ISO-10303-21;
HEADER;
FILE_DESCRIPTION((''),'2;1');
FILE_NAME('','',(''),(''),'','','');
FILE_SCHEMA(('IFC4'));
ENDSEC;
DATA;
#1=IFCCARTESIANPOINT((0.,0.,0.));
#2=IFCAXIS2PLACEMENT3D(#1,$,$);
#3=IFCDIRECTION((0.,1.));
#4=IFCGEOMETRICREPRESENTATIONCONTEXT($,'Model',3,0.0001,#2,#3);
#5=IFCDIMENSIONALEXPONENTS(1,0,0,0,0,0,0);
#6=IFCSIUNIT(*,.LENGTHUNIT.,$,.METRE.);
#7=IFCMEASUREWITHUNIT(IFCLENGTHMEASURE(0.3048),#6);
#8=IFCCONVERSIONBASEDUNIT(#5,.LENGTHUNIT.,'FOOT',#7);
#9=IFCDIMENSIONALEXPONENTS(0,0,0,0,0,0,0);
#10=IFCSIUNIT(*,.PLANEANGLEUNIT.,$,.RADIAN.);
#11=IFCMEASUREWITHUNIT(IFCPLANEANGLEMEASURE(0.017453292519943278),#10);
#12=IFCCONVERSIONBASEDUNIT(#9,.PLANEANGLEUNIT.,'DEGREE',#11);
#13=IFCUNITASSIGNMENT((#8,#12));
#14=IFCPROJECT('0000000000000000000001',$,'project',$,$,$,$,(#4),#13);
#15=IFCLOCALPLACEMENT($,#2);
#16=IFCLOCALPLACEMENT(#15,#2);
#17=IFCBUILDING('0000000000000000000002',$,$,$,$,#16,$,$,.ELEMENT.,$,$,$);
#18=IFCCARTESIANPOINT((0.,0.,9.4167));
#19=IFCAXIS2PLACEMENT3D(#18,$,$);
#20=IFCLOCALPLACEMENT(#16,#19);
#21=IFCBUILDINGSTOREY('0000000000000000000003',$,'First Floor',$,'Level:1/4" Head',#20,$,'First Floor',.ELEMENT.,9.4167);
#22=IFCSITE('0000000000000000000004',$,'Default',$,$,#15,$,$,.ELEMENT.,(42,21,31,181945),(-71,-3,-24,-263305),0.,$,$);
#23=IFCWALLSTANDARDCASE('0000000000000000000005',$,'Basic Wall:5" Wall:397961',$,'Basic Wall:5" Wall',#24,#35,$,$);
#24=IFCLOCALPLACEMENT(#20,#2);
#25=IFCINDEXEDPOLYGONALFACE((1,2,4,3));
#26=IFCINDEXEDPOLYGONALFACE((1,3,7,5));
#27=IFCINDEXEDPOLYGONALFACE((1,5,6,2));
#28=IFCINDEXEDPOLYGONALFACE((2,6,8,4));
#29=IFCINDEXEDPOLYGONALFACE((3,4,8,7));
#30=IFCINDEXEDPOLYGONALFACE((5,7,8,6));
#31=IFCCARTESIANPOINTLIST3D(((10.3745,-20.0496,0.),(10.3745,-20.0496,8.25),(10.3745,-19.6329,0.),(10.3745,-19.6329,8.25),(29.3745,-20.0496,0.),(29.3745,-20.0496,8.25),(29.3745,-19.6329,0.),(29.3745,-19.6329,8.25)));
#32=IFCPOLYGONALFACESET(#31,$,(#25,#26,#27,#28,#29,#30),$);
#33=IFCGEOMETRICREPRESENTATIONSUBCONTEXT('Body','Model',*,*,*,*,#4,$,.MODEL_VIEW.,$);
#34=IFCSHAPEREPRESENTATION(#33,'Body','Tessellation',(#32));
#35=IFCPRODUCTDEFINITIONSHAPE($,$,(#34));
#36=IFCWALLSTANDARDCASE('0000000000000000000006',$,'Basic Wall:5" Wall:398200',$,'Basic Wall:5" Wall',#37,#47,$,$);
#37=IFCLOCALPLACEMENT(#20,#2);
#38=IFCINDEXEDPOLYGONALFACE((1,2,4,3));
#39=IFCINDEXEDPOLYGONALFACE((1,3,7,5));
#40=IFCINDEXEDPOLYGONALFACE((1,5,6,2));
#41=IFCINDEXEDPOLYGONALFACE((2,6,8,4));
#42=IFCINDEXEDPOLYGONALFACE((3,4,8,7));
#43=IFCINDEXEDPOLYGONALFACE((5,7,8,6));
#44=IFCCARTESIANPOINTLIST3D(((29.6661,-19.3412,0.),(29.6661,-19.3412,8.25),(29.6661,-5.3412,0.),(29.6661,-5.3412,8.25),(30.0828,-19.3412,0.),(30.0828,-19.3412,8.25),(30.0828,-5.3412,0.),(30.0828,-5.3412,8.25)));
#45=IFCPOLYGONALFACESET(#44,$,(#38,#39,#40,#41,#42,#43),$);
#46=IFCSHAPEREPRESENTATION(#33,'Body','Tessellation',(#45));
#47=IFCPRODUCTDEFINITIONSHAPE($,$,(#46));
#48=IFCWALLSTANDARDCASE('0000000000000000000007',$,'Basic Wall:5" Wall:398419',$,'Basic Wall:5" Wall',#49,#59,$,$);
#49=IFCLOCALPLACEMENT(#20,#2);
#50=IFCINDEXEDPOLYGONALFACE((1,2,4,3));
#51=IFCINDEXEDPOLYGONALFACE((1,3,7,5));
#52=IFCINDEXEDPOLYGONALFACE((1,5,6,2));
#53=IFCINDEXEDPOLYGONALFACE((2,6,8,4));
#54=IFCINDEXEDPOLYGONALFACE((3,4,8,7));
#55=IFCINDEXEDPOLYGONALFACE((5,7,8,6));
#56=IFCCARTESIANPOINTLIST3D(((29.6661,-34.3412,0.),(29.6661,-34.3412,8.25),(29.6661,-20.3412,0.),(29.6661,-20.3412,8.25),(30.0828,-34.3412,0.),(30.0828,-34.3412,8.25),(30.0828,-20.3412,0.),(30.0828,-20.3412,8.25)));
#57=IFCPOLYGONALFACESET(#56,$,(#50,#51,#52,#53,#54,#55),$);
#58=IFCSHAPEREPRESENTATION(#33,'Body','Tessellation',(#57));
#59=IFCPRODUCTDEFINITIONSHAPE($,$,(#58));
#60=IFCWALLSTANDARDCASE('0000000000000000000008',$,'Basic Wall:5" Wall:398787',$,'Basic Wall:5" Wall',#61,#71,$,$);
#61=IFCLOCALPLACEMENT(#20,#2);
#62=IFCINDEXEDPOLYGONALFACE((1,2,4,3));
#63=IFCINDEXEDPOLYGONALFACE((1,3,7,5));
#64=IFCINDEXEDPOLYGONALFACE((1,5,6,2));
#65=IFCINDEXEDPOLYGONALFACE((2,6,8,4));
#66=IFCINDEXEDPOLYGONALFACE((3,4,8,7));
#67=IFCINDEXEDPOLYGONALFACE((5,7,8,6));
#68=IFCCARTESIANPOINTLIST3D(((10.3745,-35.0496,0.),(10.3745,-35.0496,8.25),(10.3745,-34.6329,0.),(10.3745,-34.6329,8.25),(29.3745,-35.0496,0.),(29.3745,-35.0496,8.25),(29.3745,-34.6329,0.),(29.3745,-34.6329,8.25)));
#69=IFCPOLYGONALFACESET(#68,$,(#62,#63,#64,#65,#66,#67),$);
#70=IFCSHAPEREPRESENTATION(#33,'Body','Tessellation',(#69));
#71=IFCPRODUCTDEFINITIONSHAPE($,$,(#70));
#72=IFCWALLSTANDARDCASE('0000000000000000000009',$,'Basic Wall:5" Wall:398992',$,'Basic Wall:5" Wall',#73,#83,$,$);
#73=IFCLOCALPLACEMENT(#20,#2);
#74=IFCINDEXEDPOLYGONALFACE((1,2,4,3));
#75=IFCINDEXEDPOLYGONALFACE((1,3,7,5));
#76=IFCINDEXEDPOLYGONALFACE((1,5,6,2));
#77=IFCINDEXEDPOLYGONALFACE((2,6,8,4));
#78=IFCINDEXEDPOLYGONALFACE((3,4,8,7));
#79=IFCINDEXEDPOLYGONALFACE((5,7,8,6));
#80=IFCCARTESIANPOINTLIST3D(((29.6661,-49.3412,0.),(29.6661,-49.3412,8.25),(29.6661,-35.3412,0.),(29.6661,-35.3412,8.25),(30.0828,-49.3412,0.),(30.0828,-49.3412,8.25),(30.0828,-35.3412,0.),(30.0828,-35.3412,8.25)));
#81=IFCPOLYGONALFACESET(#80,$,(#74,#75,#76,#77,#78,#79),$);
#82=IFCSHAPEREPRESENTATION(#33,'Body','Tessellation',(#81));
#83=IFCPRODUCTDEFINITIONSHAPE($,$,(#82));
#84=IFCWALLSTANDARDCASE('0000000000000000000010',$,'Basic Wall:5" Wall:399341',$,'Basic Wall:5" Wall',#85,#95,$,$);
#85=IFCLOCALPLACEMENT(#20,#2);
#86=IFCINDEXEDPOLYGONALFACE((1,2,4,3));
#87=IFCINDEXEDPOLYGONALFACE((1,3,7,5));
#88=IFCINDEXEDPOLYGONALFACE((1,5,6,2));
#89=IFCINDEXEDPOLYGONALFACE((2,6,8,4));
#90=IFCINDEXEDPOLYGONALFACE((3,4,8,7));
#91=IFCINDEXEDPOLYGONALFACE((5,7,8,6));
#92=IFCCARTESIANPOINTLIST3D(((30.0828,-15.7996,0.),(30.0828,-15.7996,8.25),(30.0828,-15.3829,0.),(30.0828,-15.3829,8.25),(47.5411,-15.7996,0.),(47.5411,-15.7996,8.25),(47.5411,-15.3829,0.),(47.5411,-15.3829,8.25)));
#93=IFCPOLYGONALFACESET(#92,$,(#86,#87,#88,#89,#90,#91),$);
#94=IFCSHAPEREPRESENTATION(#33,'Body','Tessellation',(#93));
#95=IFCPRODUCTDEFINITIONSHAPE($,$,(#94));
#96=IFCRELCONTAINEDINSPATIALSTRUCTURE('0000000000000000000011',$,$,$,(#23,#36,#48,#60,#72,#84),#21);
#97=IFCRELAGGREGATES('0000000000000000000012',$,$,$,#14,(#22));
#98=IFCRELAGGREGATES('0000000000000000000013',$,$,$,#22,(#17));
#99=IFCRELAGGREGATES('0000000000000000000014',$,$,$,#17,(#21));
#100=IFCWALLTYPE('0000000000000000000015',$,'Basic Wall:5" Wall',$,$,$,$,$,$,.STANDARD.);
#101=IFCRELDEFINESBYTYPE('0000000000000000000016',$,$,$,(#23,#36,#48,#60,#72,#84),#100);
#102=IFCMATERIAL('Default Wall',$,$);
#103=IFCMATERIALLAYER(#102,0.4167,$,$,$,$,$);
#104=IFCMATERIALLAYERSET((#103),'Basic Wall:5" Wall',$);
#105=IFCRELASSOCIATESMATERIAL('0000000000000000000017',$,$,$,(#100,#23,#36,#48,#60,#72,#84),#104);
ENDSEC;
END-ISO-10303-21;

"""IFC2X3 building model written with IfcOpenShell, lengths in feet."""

from ifc_helpers import new_model, entity, si_unit, converted_unit, direction, frame, frame_2d, origin, place, context, subcontext, project, spatial, rectangle, extrude, material, layer, layer_set, layer_usage, type_object, element, save


model = new_model("IFC2X3")

# Units and contexts
model_context = context("Model", 3, precision=0.0001, world=origin(), true_north=direction((0.0, 1.0)))
body_context = subcontext(model_context, "Body", "Model", "MODEL_VIEW")
ifc_project = project(units=[converted_unit("LENGTHUNIT", "FOOT", entity("IfcLengthMeasure", 0.3048), si_unit("LENGTHUNIT", "METRE"), dimensions=[1, 0, 0, 0, 0, 0, 0]), converted_unit("PLANEANGLEUNIT", "DEGREE", entity("IfcPlaneAngleMeasure", 0.017453292519943278), si_unit("PLANEANGLEUNIT", "RADIAN"), dimensions=[0, 0, 0, 0, 0, 0, 0])], contexts=[model_context])

# Site, building, storey
site_placement = place(None, origin())
site = spatial("IfcSite", under=ifc_project, at=site_placement, Name="Default", CompositionType="ELEMENT", RefLatitude=(42, 21, 31, 181945), RefLongitude=(-71, -3, -24, -263305), RefElevation=0.0)
building_placement = place(site_placement, origin())
building = spatial("IfcBuilding", under=site, at=building_placement, CompositionType="ELEMENT")
storey_placement = place(building_placement, frame((0.0, 0.0, 9.4167)))
storey = spatial("IfcBuildingStorey", under=building, at=storey_placement, Name="First Floor", ObjectType="Level:1/4\" Head", LongName="First Floor", CompositionType="ELEMENT", Elevation=9.4167)

# Walls
ifc_material_1 = material(Name="Default Wall")
ifc_layer_1 = layer(ifc_material_1, 0.4167)
ifc_layer_set_1 = layer_set([ifc_layer_1], Name="Basic Wall:5\" Wall")
ifc_layer_usage_1 = layer_usage(ifc_layer_set_1, "AXIS2", "NEGATIVE", 0.2083)
wall_type_1 = type_object("IfcWallType", Name="Basic Wall:5\" Wall", PredefinedType="STANDARD", material=ifc_layer_set_1)
wall_1_placement = place(storey_placement, frame((10.3745, -19.8412, 0.0)))
element("IfcWallStandardCase", 1, at=wall_1_placement, inside=storey, type_object=wall_type_1, material=ifc_layer_usage_1, Name="Basic Wall:5\" Wall:397961", ObjectType="Basic Wall:5\" Wall", context=body_context, shape_type="SweptSolid", body=[
    extrude(rectangle(XDim=19.0, YDim=0.4167, at=frame_2d((9.5, 0.0), x_axis=(-1.0, 0.0))), origin(), (0.0, 0.0, 1.0), 8.25),
])
wall_2_placement = place(storey_placement, frame((29.8745, -19.3412, 0.0), z_axis=(0.0, 0.0, 1.0), x_axis=(0.0, 1.0, 0.0)))
element("IfcWallStandardCase", 2, at=wall_2_placement, inside=storey, type_object=wall_type_1, material=ifc_layer_usage_1, Name="Basic Wall:5\" Wall:398200", ObjectType="Basic Wall:5\" Wall", context=body_context, shape_type="SweptSolid", body=[
    extrude(rectangle(XDim=14.0, YDim=0.4167, at=frame_2d((7.0, 0.0), x_axis=(-1.0, 0.0))), origin(), (0.0, 0.0, 1.0), 8.25),
])
wall_3_placement = place(storey_placement, frame((29.8745, -20.3412, 0.0), z_axis=(0.0, 0.0, 1.0), x_axis=(0.0, -1.0, 0.0)))
element("IfcWallStandardCase", 3, at=wall_3_placement, inside=storey, type_object=wall_type_1, material=ifc_layer_usage_1, Name="Basic Wall:5\" Wall:398419", ObjectType="Basic Wall:5\" Wall", context=body_context, shape_type="SweptSolid", body=[
    extrude(rectangle(XDim=14.0, YDim=0.4167, at=frame_2d((7.0, 0.0), x_axis=(-1.0, 0.0))), origin(), (0.0, 0.0, 1.0), 8.25),
])
wall_4_placement = place(storey_placement, frame((29.3745, -34.8412, 0.0), z_axis=(0.0, 0.0, 1.0), x_axis=(-1.0, 0.0, 0.0)))
element("IfcWallStandardCase", 4, at=wall_4_placement, inside=storey, type_object=wall_type_1, material=ifc_layer_usage_1, Name="Basic Wall:5\" Wall:398787", ObjectType="Basic Wall:5\" Wall", context=body_context, shape_type="SweptSolid", body=[
    extrude(rectangle(XDim=19.0, YDim=0.4167, at=frame_2d((9.5, 0.0), x_axis=(-1.0, 0.0))), origin(), (0.0, 0.0, 1.0), 8.25),
])
wall_5_placement = place(storey_placement, frame((29.8745, -35.3412, 0.0), z_axis=(0.0, 0.0, 1.0), x_axis=(0.0, -1.0, 0.0)))
element("IfcWallStandardCase", 5, at=wall_5_placement, inside=storey, type_object=wall_type_1, material=ifc_layer_usage_1, Name="Basic Wall:5\" Wall:398992", ObjectType="Basic Wall:5\" Wall", context=body_context, shape_type="SweptSolid", body=[
    extrude(rectangle(XDim=14.0, YDim=0.4167, at=frame_2d((7.0, 0.0), x_axis=(-1.0, 0.0))), origin(), (0.0, 0.0, 1.0), 8.25),
])
wall_6_placement = place(storey_placement, frame((30.0828, -15.5912, 0.0)))
element("IfcWallStandardCase", 6, at=wall_6_placement, inside=storey, type_object=wall_type_1, material=ifc_layer_usage_1, Name="Basic Wall:5\" Wall:399341", ObjectType="Basic Wall:5\" Wall", context=body_context, shape_type="SweptSolid", body=[
    extrude(rectangle(XDim=17.4583, YDim=0.4167, at=frame_2d((8.7292, 0.0), x_axis=(-1.0, 0.0))), origin(), (0.0, 0.0, 1.0), 8.25),
])

save(model, "model.ifc")
